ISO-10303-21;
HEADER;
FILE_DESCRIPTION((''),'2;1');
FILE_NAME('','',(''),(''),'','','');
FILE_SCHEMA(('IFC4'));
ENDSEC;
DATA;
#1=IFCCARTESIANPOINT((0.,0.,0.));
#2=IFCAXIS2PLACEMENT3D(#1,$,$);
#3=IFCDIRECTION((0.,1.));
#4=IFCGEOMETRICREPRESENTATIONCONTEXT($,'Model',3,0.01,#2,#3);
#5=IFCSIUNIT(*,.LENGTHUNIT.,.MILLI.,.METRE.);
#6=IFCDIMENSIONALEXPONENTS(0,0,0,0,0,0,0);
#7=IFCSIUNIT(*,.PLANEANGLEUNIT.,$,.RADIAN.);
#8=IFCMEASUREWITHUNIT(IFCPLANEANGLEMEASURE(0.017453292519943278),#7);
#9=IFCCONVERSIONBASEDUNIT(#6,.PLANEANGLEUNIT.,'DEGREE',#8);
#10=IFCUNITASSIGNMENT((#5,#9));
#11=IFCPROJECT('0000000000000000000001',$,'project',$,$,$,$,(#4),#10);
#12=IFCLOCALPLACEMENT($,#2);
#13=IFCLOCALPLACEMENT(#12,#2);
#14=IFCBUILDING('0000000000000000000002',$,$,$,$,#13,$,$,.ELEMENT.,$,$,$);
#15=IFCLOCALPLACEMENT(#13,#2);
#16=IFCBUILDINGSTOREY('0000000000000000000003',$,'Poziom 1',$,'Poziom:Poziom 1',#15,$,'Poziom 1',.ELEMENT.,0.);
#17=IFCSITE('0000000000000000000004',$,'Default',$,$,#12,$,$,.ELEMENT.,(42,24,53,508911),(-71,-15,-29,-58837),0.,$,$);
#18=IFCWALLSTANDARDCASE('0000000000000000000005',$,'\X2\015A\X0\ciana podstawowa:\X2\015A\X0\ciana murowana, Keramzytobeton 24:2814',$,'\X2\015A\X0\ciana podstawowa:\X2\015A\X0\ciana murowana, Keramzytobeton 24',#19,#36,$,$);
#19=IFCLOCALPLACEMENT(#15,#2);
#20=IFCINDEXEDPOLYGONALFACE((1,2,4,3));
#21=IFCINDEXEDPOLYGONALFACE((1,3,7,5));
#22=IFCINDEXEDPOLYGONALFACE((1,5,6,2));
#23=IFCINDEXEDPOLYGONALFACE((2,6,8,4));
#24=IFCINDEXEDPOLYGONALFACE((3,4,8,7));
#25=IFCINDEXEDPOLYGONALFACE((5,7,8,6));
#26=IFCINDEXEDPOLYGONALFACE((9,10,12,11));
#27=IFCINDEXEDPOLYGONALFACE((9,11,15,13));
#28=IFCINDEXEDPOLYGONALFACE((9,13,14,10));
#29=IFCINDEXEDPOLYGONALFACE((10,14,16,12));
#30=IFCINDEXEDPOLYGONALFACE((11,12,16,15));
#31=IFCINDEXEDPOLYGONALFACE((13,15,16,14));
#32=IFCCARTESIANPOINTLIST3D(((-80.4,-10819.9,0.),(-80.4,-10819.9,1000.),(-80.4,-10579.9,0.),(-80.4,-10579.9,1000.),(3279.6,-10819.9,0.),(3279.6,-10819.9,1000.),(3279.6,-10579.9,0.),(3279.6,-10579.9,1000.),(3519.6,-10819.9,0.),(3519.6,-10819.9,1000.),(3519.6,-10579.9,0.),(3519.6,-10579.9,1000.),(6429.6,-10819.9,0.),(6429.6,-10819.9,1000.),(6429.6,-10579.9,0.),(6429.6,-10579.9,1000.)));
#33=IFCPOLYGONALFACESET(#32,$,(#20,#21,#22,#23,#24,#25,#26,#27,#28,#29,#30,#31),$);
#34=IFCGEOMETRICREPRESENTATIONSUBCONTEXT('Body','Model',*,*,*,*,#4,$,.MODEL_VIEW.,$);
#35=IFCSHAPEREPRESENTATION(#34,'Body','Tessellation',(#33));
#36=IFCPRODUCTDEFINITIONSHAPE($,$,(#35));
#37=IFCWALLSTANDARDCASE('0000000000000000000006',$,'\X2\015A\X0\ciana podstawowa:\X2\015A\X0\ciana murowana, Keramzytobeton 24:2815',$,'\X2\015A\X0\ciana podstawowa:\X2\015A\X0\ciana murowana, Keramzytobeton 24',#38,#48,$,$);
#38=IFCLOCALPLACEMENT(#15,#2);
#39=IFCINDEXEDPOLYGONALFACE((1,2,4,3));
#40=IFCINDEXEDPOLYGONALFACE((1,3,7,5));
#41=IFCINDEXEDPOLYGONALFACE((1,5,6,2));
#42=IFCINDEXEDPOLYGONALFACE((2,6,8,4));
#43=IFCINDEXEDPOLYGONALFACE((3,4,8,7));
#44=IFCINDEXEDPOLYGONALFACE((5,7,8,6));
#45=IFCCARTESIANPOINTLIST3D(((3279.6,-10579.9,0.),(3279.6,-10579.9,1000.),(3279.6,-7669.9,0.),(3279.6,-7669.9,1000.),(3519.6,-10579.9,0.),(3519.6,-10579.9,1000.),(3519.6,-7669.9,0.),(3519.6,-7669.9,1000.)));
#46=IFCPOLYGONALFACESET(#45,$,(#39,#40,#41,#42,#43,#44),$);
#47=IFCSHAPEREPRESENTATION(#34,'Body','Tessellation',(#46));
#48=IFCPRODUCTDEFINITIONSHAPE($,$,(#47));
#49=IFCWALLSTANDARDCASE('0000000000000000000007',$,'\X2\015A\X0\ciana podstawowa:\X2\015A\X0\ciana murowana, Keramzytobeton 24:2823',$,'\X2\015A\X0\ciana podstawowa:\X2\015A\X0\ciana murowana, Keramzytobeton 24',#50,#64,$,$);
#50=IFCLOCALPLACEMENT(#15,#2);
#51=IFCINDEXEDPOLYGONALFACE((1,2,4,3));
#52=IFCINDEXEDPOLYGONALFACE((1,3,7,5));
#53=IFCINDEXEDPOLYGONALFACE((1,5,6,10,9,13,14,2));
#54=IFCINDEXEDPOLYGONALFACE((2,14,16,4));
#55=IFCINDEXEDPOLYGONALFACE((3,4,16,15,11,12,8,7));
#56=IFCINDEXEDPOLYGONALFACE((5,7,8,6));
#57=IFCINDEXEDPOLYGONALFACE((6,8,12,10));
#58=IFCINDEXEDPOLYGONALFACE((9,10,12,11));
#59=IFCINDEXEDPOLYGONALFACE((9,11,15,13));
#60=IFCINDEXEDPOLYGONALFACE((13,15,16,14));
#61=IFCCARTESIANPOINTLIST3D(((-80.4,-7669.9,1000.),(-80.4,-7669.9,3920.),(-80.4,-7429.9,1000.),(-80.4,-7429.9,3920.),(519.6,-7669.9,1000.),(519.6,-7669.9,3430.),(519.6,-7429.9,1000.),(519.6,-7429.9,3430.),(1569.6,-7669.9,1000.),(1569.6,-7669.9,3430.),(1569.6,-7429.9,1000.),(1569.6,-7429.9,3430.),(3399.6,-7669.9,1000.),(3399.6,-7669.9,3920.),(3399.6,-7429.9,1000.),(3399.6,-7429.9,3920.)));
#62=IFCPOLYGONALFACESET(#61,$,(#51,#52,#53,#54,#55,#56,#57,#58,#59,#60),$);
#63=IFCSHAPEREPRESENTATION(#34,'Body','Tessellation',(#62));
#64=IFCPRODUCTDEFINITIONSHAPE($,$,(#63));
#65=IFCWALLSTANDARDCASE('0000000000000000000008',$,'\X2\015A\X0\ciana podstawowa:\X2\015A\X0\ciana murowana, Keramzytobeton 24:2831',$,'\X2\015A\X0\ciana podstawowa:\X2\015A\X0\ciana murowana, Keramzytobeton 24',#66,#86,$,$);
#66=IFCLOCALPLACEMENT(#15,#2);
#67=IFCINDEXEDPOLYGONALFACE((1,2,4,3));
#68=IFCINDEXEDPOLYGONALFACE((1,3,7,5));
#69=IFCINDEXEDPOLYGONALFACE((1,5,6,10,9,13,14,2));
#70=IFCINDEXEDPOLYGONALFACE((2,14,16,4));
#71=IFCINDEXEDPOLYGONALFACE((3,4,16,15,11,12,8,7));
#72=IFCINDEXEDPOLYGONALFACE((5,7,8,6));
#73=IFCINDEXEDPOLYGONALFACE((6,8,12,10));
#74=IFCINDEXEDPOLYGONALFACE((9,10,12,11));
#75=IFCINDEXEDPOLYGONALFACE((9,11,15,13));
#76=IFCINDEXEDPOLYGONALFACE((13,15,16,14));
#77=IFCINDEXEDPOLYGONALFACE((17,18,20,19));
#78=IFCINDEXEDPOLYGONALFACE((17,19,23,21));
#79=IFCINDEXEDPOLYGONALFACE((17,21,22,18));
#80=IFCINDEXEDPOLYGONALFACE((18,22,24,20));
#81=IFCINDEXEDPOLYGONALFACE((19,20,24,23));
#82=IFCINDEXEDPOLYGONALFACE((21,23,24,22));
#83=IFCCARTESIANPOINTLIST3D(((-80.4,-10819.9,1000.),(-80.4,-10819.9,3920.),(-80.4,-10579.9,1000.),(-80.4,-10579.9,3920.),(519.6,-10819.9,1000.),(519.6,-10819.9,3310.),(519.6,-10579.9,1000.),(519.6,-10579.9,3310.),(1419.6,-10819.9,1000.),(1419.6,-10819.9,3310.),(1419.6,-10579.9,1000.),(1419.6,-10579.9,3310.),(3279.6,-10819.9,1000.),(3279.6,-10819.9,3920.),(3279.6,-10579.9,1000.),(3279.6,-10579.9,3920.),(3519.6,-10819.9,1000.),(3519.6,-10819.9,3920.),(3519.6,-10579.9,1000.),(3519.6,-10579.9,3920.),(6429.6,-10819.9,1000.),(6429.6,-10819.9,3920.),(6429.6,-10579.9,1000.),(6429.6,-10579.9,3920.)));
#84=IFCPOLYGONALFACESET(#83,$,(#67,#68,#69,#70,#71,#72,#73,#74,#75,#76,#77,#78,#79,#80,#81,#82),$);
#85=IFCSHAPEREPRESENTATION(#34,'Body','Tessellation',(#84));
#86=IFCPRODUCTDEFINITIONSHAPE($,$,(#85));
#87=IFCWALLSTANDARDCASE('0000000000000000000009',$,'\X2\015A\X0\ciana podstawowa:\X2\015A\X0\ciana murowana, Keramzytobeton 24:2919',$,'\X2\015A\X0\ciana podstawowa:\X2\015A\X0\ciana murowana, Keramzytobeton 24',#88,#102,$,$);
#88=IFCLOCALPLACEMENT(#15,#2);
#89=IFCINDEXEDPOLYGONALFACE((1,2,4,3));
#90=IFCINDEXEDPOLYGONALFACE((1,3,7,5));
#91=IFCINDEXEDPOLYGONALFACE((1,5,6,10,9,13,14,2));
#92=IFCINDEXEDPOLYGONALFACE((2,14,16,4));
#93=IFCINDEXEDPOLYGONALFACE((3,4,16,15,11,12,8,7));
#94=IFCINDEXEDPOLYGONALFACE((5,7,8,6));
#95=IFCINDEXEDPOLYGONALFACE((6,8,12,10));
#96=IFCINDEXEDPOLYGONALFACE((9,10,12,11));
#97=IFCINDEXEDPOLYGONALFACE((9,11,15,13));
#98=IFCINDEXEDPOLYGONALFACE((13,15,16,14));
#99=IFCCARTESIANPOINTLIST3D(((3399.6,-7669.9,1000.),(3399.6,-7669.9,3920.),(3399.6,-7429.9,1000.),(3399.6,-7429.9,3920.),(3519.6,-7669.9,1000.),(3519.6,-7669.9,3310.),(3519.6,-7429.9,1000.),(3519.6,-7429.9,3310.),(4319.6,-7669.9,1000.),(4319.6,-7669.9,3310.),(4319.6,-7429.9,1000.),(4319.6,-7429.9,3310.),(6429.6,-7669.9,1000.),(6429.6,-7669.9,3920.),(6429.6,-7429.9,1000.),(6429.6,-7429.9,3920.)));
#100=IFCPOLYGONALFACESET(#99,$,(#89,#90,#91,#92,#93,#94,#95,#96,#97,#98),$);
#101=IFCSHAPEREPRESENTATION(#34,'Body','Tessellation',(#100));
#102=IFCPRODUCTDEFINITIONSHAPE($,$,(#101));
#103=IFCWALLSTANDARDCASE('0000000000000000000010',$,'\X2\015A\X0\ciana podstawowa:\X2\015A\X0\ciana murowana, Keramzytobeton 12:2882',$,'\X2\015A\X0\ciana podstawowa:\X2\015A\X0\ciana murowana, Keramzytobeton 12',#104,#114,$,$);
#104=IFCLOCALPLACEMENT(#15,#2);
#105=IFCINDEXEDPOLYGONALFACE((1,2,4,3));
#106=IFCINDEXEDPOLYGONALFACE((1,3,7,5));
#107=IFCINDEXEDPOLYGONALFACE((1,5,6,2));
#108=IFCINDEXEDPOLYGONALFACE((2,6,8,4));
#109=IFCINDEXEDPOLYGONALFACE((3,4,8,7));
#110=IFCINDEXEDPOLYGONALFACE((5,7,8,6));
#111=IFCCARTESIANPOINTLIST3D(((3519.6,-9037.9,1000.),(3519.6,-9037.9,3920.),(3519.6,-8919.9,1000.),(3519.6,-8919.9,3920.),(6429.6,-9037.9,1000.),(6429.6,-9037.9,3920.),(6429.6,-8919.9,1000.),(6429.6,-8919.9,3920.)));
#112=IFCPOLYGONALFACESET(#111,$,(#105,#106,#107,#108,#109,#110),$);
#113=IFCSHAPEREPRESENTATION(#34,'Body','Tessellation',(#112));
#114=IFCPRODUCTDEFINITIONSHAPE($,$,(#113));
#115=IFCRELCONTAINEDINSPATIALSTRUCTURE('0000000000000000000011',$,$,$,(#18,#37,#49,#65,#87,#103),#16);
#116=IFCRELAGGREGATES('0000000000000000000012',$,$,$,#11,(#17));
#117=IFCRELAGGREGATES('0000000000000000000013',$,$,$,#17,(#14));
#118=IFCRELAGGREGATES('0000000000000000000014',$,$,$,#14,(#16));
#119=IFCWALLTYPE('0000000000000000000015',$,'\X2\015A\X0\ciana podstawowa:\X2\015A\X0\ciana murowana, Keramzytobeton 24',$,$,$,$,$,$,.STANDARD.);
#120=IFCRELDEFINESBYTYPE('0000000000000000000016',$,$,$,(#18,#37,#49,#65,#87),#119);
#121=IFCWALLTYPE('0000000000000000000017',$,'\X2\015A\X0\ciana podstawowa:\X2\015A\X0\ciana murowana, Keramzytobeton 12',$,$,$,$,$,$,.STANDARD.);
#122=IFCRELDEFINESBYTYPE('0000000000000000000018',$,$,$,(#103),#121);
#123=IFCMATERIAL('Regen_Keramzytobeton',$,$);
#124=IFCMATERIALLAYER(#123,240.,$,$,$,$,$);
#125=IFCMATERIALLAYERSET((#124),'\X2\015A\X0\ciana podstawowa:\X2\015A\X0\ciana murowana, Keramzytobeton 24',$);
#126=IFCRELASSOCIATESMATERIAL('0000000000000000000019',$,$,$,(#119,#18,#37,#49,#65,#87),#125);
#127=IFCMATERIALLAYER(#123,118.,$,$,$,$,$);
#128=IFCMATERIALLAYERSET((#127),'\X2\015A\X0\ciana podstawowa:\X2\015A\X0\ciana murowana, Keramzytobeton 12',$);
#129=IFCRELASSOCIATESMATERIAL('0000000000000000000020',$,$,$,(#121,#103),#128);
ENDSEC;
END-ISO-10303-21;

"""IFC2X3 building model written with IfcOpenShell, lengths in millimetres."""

from ifc_helpers import new_model, entity, si_unit, converted_unit, direction, frame, frame_2d, origin, place, context, subcontext, project, spatial, rectangle, extrude, material, layer, layer_set, layer_usage, type_object, element, save


model = new_model("IFC2X3")

# Units and contexts
model_context = context("Model", 3, precision=0.01, world=origin(), true_north=direction((0.0, 1.0)))
body_context = subcontext(model_context, "Body", "Model", "MODEL_VIEW")
ifc_project = project(units=[si_unit("LENGTHUNIT", "METRE", prefix="MILLI"), converted_unit("PLANEANGLEUNIT", "DEGREE", entity("IfcPlaneAngleMeasure", 0.017453292519943278), si_unit("PLANEANGLEUNIT", "RADIAN"), dimensions=[0, 0, 0, 0, 0, 0, 0])], contexts=[model_context])

# Site, building, storey
site_placement = place(None, origin())
site = spatial("IfcSite", under=ifc_project, at=site_placement, Name="Default", CompositionType="ELEMENT", RefLatitude=(42, 24, 53, 508911), RefLongitude=(-71, -15, -29, -58837), RefElevation=0.0)
building_placement = place(site_placement, origin())
building = spatial("IfcBuilding", under=site, at=building_placement, CompositionType="ELEMENT")
storey_placement = place(building_placement, origin())
storey = spatial("IfcBuildingStorey", under=building, at=storey_placement, Name="Poziom 1", ObjectType="Poziom:Poziom 1", LongName="Poziom 1", CompositionType="ELEMENT", Elevation=0.0)

# Shared definitions
ifc_material_1 = material(Name="Regen_Keramzytobeton")
ifc_layer_1 = layer(ifc_material_1, 240.0)
ifc_layer_set_1 = layer_set([ifc_layer_1], Name="Ściana podstawowa:Ściana murowana, Keramzytobeton 24")
wall_type_1 = type_object("IfcWallType", Name="Ściana podstawowa:Ściana murowana, Keramzytobeton 24", PredefinedType="STANDARD", material=ifc_layer_set_1)

# Wall, opening
ifc_layer_usage_1 = layer_usage(ifc_layer_set_1, "AXIS2", "NEGATIVE", 120.0)
wall_1_placement = place(storey_placement, frame((-80.4, -10699.9, 0.0)))
wall_1 = element("IfcWallStandardCase", 1, at=wall_1_placement, inside=storey, type_object=wall_type_1, material=ifc_layer_usage_1, Name="Ściana podstawowa:Ściana murowana, Keramzytobeton 24:2814", ObjectType="Ściana podstawowa:Ściana murowana, Keramzytobeton 24", context=body_context, shape_type="SweptSolid", body=[
    extrude(rectangle(XDim=6510.0, YDim=240.0, at=frame_2d((3255.0, 0.0), x_axis=(-1.0, 0.0))), origin(), (0.0, 0.0, 1.0), 1000.0),
])
opening_1_placement = place(storey_placement, frame((-80.4, -10699.9, 0.0)))
element("IfcOpeningElement", 2, at=opening_1_placement, cuts=wall_1, ObjectType="Opening", context=body_context, shape_type="SweptSolid", body=[
    extrude(rectangle(XDim=1000.0, YDim=240.0, at=frame_2d((0.0, 0.0), x_axis=(1.0, 0.0))), frame((3360.0, 0.0, 500.0), z_axis=(1.0, 0.0, 0.0), x_axis=(0.0, 0.0, -1.0)), (0.0, 0.0, 1.0), 240.0),
])

# Wall
ifc_layer_usage_2 = layer_usage(ifc_layer_set_1, "AXIS2", "NEGATIVE", 120.0)
wall_2_placement = place(storey_placement, frame((3399.6, -10579.9, 0.0), z_axis=(0.0, 0.0, 1.0), x_axis=(0.0, 1.0, 0.0)))
element("IfcWallStandardCase", 3, at=wall_2_placement, inside=storey, type_object=wall_type_1, material=ifc_layer_usage_2, Name="Ściana podstawowa:Ściana murowana, Keramzytobeton 24:2815", ObjectType="Ściana podstawowa:Ściana murowana, Keramzytobeton 24", context=body_context, shape_type="SweptSolid", body=[
    extrude(rectangle(XDim=2910.0, YDim=240.0, at=frame_2d((1455.0, 0.0), x_axis=(-1.0, 0.0))), origin(), (0.0, 0.0, 1.0), 1000.0),
])

# Wall, opening
ifc_layer_usage_3 = layer_usage(ifc_layer_set_1, "AXIS2", "NEGATIVE", 120.0)
wall_3_placement = place(storey_placement, frame((-80.4, -7549.9, 1000.0)))
wall_3 = element("IfcWallStandardCase", 4, at=wall_3_placement, inside=storey, type_object=wall_type_1, material=ifc_layer_usage_3, Name="Ściana podstawowa:Ściana murowana, Keramzytobeton 24:2823", ObjectType="Ściana podstawowa:Ściana murowana, Keramzytobeton 24", context=body_context, shape_type="SweptSolid", body=[
    extrude(rectangle(XDim=3480.0, YDim=240.0, at=frame_2d((1740.0, 0.0), x_axis=(-1.0, 0.0))), origin(), (0.0, 0.0, 1.0), 2920.0),
])
opening_2_placement = place(wall_3_placement, frame((80.4, 7549.9, -1000.0)))
element("IfcOpeningElement", 5, at=opening_2_placement, cuts=wall_3, ObjectType="Opening", context=body_context, shape_type="SweptSolid", body=[
    extrude(rectangle(XDim=2430.0, YDim=1050.0, at=frame_2d((0.0, 0.0), x_axis=(0.0, 1.0))), frame((1044.6, -9193.9, 2215.0), z_axis=(0.0, 1.0, 0.0), x_axis=(1.0, 0.0, 0.0)), (0.0, 0.0, 1.0), 3048.0),
])

# Wall, openings
ifc_layer_usage_4 = layer_usage(ifc_layer_set_1, "AXIS2", "NEGATIVE", 120.0)
wall_4_placement = place(storey_placement, frame((-80.4, -10699.9, 1000.0)))
wall_4 = element("IfcWallStandardCase", 6, at=wall_4_placement, inside=storey, type_object=wall_type_1, material=ifc_layer_usage_4, Name="Ściana podstawowa:Ściana murowana, Keramzytobeton 24:2831", ObjectType="Ściana podstawowa:Ściana murowana, Keramzytobeton 24", context=body_context, shape_type="SweptSolid", body=[
    extrude(rectangle(XDim=6510.0, YDim=240.0, at=frame_2d((3255.0, 0.0), x_axis=(-1.0, 0.0))), origin(), (0.0, 0.0, 1.0), 2920.0),
])
opening_3_placement = place(storey_placement, frame((-80.4, -10699.9, 1000.0)))
element("IfcOpeningElement", 7, at=opening_3_placement, cuts=wall_4, ObjectType="Opening", context=body_context, shape_type="SweptSolid", body=[
    extrude(rectangle(XDim=2920.0, YDim=240.0, at=frame_2d((0.0, 0.0), x_axis=(1.0, 0.0))), frame((3360.0, 0.0, 1460.0), z_axis=(1.0, 0.0, 0.0), x_axis=(0.0, 0.0, -1.0)), (0.0, 0.0, 1.0), 240.0),
])
opening_4_placement = place(wall_4_placement, frame((80.4, 10699.9, -1000.0)))
element("IfcOpeningElement", 8, at=opening_4_placement, cuts=wall_4, ObjectType="Opening", context=body_context, shape_type="SweptSolid", body=[
    extrude(rectangle(XDim=2310.0, YDim=900.0, at=frame_2d((0.0, 0.0), x_axis=(1.0, 0.0))), frame((969.6, -12103.9, 2155.0), z_axis=(0.0, 1.0, 0.0), x_axis=(0.0, 0.0, -1.0)), (0.0, 0.0, 1.0), 3048.0),
])

# Wall, opening
ifc_layer_usage_5 = layer_usage(ifc_layer_set_1, "AXIS2", "NEGATIVE", 120.0)
wall_5_placement = place(storey_placement, frame((3399.6, -7549.9, 1000.0)))
wall_5 = element("IfcWallStandardCase", 9, at=wall_5_placement, inside=storey, type_object=wall_type_1, material=ifc_layer_usage_5, Name="Ściana podstawowa:Ściana murowana, Keramzytobeton 24:2919", ObjectType="Ściana podstawowa:Ściana murowana, Keramzytobeton 24", context=body_context, shape_type="SweptSolid", body=[
    extrude(rectangle(XDim=3030.0, YDim=240.0, at=frame_2d((1515.0, 0.0), x_axis=(-1.0, 0.0))), origin(), (0.0, 0.0, 1.0), 2920.0),
])
opening_5_placement = place(wall_5_placement, origin())
element("IfcOpeningElement", 10, at=opening_5_placement, cuts=wall_5, ObjectType="Opening", context=body_context, shape_type="SweptSolid", body=[
    extrude(rectangle(XDim=2310.0, YDim=800.0, at=frame_2d((0.0, 0.0), x_axis=(1.0, 0.0))), frame((520.0, -1404.0, 1155.0), z_axis=(0.0, 1.0, 0.0), x_axis=(0.0, 0.0, -1.0)), (0.0, 0.0, 1.0), 3048.0),
])

# Wall
ifc_layer_2 = layer(ifc_material_1, 118.0)
ifc_layer_set_2 = layer_set([ifc_layer_2], Name="Ściana podstawowa:Ściana murowana, Keramzytobeton 12")
ifc_layer_usage_6 = layer_usage(ifc_layer_set_2, "AXIS2", "NEGATIVE", 59.0)
wall_type_2 = type_object("IfcWallType", Name="Ściana podstawowa:Ściana murowana, Keramzytobeton 12", PredefinedType="STANDARD", material=ifc_layer_set_2)
wall_6_placement = place(storey_placement, frame((3519.6, -8978.9, 1000.0)))
element("IfcWallStandardCase", 11, at=wall_6_placement, inside=storey, type_object=wall_type_2, material=ifc_layer_usage_6, Name="Ściana podstawowa:Ściana murowana, Keramzytobeton 12:2882", ObjectType="Ściana podstawowa:Ściana murowana, Keramzytobeton 12", context=body_context, shape_type="SweptSolid", body=[
    extrude(rectangle(XDim=2910.0, YDim=118.0, at=frame_2d((1455.0, 0.0), x_axis=(-1.0, 0.0))), origin(), (0.0, 0.0, 1.0), 2920.0),
])

save(model, "model.ifc")
